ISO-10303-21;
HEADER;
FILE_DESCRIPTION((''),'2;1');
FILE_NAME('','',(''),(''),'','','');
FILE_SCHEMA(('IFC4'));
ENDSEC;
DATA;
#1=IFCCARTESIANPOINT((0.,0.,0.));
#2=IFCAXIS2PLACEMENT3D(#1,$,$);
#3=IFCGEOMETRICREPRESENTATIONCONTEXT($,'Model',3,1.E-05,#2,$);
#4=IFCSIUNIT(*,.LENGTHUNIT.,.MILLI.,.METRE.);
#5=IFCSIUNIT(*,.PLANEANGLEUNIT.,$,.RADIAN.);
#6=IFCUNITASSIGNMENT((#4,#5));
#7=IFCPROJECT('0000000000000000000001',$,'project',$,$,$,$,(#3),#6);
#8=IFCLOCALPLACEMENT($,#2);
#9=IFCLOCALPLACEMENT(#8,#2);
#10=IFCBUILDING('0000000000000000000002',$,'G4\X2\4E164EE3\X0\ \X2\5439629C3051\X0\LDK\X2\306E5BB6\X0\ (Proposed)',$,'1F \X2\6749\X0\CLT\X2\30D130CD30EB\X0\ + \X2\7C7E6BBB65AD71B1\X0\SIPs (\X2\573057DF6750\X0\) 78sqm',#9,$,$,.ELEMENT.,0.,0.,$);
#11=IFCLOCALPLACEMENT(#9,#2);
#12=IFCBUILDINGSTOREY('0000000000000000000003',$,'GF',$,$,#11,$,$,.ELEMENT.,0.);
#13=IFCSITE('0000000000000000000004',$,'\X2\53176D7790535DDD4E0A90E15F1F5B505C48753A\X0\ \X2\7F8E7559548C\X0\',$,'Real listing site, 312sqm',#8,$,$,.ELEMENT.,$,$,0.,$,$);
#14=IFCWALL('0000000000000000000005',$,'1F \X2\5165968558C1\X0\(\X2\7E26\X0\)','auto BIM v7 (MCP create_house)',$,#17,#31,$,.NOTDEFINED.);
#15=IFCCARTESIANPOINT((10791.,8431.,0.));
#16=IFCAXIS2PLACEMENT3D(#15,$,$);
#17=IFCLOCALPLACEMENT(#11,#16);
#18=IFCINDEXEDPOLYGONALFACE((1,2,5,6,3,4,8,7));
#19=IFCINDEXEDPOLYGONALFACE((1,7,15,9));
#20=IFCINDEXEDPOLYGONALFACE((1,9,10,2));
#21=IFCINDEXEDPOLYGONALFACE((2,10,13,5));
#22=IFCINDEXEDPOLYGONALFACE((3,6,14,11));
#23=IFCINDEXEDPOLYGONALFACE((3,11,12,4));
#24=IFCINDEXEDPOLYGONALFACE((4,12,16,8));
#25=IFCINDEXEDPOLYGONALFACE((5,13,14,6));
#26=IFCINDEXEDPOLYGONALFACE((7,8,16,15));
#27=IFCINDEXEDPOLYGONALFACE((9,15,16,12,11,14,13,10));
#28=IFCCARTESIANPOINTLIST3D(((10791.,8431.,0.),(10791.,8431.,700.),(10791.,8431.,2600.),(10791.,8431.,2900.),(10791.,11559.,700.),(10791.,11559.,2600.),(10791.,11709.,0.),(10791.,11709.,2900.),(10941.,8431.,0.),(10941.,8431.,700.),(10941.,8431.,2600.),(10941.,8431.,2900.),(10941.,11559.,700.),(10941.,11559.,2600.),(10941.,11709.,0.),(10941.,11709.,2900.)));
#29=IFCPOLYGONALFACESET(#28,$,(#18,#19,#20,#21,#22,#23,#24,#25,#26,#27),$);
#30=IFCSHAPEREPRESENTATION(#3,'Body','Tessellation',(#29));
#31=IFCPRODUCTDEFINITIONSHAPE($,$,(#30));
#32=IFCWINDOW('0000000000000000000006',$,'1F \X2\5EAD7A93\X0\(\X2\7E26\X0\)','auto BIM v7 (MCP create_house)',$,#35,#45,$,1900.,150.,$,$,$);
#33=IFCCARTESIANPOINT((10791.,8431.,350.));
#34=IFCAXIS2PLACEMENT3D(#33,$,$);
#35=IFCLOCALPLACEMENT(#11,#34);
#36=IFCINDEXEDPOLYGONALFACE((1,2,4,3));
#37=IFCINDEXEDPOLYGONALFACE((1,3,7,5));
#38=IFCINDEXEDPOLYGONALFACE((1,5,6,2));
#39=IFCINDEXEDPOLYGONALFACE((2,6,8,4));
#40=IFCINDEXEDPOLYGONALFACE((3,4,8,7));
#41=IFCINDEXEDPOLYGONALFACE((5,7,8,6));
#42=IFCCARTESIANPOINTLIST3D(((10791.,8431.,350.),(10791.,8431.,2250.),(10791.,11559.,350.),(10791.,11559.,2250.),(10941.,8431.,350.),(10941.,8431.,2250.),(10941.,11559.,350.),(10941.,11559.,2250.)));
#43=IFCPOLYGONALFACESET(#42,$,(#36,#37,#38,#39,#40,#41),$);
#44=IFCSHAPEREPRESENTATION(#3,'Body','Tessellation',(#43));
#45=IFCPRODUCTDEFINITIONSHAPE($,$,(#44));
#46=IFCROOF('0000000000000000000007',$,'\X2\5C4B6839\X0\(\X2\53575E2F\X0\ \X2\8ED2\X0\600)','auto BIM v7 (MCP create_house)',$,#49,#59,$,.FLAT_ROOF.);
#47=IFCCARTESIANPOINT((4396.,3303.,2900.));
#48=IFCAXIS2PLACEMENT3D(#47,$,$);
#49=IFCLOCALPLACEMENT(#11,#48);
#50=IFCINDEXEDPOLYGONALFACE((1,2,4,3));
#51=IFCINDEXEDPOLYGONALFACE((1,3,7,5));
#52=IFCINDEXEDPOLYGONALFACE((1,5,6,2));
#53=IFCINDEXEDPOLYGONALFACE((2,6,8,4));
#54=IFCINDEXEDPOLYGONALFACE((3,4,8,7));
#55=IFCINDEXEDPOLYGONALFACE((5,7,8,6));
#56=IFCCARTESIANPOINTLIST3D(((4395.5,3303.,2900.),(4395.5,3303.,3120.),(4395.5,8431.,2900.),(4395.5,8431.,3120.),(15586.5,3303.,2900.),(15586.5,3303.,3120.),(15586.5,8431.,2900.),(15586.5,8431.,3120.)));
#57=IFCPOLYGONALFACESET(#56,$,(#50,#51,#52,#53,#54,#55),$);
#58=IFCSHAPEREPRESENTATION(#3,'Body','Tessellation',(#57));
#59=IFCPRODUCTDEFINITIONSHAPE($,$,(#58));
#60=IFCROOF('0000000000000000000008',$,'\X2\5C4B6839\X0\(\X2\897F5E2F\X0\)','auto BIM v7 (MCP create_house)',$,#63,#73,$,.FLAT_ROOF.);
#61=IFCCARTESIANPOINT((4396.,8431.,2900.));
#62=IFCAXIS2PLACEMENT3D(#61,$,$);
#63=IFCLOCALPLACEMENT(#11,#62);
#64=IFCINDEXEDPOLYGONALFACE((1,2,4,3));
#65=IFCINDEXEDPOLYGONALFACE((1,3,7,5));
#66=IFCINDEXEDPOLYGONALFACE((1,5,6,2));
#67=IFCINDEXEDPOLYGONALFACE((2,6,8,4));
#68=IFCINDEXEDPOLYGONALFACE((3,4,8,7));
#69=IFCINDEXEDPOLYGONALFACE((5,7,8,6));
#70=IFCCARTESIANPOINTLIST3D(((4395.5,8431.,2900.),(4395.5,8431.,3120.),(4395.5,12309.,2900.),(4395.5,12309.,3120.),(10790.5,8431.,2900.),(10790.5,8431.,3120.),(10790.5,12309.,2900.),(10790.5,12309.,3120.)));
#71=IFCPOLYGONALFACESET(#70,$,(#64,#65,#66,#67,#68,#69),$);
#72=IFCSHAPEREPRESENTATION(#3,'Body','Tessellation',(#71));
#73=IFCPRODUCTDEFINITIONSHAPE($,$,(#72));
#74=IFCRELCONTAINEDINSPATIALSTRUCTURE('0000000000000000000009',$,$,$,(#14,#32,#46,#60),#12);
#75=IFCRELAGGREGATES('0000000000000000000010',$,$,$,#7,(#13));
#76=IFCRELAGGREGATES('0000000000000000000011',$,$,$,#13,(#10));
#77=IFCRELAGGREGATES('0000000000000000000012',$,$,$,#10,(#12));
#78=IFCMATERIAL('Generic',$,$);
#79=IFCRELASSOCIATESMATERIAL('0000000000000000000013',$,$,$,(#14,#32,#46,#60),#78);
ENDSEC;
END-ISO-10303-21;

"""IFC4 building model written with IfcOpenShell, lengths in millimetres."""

from ifc_helpers import new_model, si_unit, frame, frame_2d, origin, place, context, project, spatial, rectangle, extrude, material, element, fill, save


model = new_model("IFC4")

# Units and contexts
model_context = context("Model", 3, precision=1e-05, world=origin())
ifc_project = project(units=[si_unit("LENGTHUNIT", "METRE", prefix="MILLI"), si_unit("PLANEANGLEUNIT", "RADIAN")], contexts=[model_context])

# Site, building, storey
site_placement = place(None, origin())
site = spatial("IfcSite", under=ifc_project, at=site_placement, Name="北海道川上郡弟子屈町 美留和", ObjectType="Real listing site, 312sqm", CompositionType="ELEMENT", RefElevation=0.0)
building_placement = place(site_placement, origin())
building = spatial("IfcBuilding", under=site, at=building_placement, Name="G4世代 吹抜けLDKの家 (Proposed)", ObjectType="1F 杉CLTパネル + 籾殻断熱SIPs (地域材) 78sqm", CompositionType="ELEMENT", ElevationOfRefHeight=0.0, ElevationOfTerrain=0.0)
storey_placement = place(building_placement, origin())
storey = spatial("IfcBuildingStorey", under=building, at=storey_placement, Name="GF", CompositionType="ELEMENT", Elevation=0.0)

# Shared definitions
ifc_material = material(Name="Generic")

# Wall, opening, window
wall_1_placement = place(storey_placement, frame((10791.0, 8431.0, 0.0)))
wall_1 = element("IfcWall", 1, at=wall_1_placement, inside=storey, material=ifc_material, Name="1F 入隅壁(縦)", Description="auto BIM v7 (MCP create_house)", PredefinedType="NOTDEFINED", context=model_context, shape_type="SweptSolid", body=[
    extrude(rectangle(XDim=150.0, YDim=3278.0, at=frame_2d((75.0, 1639.0))), frame((10791.0, 8431.0, 0.0)), (0.0, 0.0, 1.0), 2900.0),
])
opening_1_placement = place(storey_placement, frame((10791.0, 8431.0, 350.0)))
opening_1 = element("IfcOpeningElement", 2, at=opening_1_placement, cuts=wall_1, PredefinedType="NOTDEFINED", context=model_context, shape_type="SweptSolid", body=[
    extrude(rectangle(XDim=150.0, YDim=3128.0, at=frame_2d((75.0, 1564.0))), frame((10791.0, 8431.0, 350.0)), (0.0, 0.0, 1.0), 1900.0),
])
window_1_placement = place(storey_placement, frame((10791.0, 8431.0, 350.0)))
window_1 = element("IfcWindow", 3, at=window_1_placement, inside=storey, material=ifc_material, Name="1F 庭窓(縦)", Description="auto BIM v7 (MCP create_house)", OverallHeight=1900.0, OverallWidth=150.0, context=model_context, shape_type="SweptSolid", body=[
    extrude(rectangle(XDim=150.0, YDim=3128.0, at=frame_2d((75.0, 1564.0))), frame((10791.0, 8431.0, 350.0)), (0.0, 0.0, 1.0), 1900.0),
])
fill(opening_1, window_1)

# Roofs
roof_1_placement = place(storey_placement, frame((4396.0, 3303.0, 2900.0)))
element("IfcRoof", 4, at=roof_1_placement, inside=storey, material=ifc_material, Name="屋根(南帯 軒600)", Description="auto BIM v7 (MCP create_house)", PredefinedType="FLAT_ROOF", context=model_context, shape_type="SweptSolid", body=[
    extrude(rectangle(XDim=11191.0, YDim=5128.0, at=frame_2d((5595.0, 2564.0))), frame((4396.0, 3303.0, 2900.0)), (0.0, 0.0, 1.0), 220.0),
])
roof_2_placement = place(storey_placement, frame((4396.0, 8431.0, 2900.0)))
element("IfcRoof", 5, at=roof_2_placement, inside=storey, material=ifc_material, Name="屋根(西帯)", Description="auto BIM v7 (MCP create_house)", PredefinedType="FLAT_ROOF", context=model_context, shape_type="SweptSolid", body=[
    extrude(rectangle(XDim=6395.0, YDim=3878.0, at=frame_2d((3197.0, 1939.0))), frame((4396.0, 8431.0, 2900.0)), (0.0, 0.0, 1.0), 220.0),
])

save(model, "model.ifc")
